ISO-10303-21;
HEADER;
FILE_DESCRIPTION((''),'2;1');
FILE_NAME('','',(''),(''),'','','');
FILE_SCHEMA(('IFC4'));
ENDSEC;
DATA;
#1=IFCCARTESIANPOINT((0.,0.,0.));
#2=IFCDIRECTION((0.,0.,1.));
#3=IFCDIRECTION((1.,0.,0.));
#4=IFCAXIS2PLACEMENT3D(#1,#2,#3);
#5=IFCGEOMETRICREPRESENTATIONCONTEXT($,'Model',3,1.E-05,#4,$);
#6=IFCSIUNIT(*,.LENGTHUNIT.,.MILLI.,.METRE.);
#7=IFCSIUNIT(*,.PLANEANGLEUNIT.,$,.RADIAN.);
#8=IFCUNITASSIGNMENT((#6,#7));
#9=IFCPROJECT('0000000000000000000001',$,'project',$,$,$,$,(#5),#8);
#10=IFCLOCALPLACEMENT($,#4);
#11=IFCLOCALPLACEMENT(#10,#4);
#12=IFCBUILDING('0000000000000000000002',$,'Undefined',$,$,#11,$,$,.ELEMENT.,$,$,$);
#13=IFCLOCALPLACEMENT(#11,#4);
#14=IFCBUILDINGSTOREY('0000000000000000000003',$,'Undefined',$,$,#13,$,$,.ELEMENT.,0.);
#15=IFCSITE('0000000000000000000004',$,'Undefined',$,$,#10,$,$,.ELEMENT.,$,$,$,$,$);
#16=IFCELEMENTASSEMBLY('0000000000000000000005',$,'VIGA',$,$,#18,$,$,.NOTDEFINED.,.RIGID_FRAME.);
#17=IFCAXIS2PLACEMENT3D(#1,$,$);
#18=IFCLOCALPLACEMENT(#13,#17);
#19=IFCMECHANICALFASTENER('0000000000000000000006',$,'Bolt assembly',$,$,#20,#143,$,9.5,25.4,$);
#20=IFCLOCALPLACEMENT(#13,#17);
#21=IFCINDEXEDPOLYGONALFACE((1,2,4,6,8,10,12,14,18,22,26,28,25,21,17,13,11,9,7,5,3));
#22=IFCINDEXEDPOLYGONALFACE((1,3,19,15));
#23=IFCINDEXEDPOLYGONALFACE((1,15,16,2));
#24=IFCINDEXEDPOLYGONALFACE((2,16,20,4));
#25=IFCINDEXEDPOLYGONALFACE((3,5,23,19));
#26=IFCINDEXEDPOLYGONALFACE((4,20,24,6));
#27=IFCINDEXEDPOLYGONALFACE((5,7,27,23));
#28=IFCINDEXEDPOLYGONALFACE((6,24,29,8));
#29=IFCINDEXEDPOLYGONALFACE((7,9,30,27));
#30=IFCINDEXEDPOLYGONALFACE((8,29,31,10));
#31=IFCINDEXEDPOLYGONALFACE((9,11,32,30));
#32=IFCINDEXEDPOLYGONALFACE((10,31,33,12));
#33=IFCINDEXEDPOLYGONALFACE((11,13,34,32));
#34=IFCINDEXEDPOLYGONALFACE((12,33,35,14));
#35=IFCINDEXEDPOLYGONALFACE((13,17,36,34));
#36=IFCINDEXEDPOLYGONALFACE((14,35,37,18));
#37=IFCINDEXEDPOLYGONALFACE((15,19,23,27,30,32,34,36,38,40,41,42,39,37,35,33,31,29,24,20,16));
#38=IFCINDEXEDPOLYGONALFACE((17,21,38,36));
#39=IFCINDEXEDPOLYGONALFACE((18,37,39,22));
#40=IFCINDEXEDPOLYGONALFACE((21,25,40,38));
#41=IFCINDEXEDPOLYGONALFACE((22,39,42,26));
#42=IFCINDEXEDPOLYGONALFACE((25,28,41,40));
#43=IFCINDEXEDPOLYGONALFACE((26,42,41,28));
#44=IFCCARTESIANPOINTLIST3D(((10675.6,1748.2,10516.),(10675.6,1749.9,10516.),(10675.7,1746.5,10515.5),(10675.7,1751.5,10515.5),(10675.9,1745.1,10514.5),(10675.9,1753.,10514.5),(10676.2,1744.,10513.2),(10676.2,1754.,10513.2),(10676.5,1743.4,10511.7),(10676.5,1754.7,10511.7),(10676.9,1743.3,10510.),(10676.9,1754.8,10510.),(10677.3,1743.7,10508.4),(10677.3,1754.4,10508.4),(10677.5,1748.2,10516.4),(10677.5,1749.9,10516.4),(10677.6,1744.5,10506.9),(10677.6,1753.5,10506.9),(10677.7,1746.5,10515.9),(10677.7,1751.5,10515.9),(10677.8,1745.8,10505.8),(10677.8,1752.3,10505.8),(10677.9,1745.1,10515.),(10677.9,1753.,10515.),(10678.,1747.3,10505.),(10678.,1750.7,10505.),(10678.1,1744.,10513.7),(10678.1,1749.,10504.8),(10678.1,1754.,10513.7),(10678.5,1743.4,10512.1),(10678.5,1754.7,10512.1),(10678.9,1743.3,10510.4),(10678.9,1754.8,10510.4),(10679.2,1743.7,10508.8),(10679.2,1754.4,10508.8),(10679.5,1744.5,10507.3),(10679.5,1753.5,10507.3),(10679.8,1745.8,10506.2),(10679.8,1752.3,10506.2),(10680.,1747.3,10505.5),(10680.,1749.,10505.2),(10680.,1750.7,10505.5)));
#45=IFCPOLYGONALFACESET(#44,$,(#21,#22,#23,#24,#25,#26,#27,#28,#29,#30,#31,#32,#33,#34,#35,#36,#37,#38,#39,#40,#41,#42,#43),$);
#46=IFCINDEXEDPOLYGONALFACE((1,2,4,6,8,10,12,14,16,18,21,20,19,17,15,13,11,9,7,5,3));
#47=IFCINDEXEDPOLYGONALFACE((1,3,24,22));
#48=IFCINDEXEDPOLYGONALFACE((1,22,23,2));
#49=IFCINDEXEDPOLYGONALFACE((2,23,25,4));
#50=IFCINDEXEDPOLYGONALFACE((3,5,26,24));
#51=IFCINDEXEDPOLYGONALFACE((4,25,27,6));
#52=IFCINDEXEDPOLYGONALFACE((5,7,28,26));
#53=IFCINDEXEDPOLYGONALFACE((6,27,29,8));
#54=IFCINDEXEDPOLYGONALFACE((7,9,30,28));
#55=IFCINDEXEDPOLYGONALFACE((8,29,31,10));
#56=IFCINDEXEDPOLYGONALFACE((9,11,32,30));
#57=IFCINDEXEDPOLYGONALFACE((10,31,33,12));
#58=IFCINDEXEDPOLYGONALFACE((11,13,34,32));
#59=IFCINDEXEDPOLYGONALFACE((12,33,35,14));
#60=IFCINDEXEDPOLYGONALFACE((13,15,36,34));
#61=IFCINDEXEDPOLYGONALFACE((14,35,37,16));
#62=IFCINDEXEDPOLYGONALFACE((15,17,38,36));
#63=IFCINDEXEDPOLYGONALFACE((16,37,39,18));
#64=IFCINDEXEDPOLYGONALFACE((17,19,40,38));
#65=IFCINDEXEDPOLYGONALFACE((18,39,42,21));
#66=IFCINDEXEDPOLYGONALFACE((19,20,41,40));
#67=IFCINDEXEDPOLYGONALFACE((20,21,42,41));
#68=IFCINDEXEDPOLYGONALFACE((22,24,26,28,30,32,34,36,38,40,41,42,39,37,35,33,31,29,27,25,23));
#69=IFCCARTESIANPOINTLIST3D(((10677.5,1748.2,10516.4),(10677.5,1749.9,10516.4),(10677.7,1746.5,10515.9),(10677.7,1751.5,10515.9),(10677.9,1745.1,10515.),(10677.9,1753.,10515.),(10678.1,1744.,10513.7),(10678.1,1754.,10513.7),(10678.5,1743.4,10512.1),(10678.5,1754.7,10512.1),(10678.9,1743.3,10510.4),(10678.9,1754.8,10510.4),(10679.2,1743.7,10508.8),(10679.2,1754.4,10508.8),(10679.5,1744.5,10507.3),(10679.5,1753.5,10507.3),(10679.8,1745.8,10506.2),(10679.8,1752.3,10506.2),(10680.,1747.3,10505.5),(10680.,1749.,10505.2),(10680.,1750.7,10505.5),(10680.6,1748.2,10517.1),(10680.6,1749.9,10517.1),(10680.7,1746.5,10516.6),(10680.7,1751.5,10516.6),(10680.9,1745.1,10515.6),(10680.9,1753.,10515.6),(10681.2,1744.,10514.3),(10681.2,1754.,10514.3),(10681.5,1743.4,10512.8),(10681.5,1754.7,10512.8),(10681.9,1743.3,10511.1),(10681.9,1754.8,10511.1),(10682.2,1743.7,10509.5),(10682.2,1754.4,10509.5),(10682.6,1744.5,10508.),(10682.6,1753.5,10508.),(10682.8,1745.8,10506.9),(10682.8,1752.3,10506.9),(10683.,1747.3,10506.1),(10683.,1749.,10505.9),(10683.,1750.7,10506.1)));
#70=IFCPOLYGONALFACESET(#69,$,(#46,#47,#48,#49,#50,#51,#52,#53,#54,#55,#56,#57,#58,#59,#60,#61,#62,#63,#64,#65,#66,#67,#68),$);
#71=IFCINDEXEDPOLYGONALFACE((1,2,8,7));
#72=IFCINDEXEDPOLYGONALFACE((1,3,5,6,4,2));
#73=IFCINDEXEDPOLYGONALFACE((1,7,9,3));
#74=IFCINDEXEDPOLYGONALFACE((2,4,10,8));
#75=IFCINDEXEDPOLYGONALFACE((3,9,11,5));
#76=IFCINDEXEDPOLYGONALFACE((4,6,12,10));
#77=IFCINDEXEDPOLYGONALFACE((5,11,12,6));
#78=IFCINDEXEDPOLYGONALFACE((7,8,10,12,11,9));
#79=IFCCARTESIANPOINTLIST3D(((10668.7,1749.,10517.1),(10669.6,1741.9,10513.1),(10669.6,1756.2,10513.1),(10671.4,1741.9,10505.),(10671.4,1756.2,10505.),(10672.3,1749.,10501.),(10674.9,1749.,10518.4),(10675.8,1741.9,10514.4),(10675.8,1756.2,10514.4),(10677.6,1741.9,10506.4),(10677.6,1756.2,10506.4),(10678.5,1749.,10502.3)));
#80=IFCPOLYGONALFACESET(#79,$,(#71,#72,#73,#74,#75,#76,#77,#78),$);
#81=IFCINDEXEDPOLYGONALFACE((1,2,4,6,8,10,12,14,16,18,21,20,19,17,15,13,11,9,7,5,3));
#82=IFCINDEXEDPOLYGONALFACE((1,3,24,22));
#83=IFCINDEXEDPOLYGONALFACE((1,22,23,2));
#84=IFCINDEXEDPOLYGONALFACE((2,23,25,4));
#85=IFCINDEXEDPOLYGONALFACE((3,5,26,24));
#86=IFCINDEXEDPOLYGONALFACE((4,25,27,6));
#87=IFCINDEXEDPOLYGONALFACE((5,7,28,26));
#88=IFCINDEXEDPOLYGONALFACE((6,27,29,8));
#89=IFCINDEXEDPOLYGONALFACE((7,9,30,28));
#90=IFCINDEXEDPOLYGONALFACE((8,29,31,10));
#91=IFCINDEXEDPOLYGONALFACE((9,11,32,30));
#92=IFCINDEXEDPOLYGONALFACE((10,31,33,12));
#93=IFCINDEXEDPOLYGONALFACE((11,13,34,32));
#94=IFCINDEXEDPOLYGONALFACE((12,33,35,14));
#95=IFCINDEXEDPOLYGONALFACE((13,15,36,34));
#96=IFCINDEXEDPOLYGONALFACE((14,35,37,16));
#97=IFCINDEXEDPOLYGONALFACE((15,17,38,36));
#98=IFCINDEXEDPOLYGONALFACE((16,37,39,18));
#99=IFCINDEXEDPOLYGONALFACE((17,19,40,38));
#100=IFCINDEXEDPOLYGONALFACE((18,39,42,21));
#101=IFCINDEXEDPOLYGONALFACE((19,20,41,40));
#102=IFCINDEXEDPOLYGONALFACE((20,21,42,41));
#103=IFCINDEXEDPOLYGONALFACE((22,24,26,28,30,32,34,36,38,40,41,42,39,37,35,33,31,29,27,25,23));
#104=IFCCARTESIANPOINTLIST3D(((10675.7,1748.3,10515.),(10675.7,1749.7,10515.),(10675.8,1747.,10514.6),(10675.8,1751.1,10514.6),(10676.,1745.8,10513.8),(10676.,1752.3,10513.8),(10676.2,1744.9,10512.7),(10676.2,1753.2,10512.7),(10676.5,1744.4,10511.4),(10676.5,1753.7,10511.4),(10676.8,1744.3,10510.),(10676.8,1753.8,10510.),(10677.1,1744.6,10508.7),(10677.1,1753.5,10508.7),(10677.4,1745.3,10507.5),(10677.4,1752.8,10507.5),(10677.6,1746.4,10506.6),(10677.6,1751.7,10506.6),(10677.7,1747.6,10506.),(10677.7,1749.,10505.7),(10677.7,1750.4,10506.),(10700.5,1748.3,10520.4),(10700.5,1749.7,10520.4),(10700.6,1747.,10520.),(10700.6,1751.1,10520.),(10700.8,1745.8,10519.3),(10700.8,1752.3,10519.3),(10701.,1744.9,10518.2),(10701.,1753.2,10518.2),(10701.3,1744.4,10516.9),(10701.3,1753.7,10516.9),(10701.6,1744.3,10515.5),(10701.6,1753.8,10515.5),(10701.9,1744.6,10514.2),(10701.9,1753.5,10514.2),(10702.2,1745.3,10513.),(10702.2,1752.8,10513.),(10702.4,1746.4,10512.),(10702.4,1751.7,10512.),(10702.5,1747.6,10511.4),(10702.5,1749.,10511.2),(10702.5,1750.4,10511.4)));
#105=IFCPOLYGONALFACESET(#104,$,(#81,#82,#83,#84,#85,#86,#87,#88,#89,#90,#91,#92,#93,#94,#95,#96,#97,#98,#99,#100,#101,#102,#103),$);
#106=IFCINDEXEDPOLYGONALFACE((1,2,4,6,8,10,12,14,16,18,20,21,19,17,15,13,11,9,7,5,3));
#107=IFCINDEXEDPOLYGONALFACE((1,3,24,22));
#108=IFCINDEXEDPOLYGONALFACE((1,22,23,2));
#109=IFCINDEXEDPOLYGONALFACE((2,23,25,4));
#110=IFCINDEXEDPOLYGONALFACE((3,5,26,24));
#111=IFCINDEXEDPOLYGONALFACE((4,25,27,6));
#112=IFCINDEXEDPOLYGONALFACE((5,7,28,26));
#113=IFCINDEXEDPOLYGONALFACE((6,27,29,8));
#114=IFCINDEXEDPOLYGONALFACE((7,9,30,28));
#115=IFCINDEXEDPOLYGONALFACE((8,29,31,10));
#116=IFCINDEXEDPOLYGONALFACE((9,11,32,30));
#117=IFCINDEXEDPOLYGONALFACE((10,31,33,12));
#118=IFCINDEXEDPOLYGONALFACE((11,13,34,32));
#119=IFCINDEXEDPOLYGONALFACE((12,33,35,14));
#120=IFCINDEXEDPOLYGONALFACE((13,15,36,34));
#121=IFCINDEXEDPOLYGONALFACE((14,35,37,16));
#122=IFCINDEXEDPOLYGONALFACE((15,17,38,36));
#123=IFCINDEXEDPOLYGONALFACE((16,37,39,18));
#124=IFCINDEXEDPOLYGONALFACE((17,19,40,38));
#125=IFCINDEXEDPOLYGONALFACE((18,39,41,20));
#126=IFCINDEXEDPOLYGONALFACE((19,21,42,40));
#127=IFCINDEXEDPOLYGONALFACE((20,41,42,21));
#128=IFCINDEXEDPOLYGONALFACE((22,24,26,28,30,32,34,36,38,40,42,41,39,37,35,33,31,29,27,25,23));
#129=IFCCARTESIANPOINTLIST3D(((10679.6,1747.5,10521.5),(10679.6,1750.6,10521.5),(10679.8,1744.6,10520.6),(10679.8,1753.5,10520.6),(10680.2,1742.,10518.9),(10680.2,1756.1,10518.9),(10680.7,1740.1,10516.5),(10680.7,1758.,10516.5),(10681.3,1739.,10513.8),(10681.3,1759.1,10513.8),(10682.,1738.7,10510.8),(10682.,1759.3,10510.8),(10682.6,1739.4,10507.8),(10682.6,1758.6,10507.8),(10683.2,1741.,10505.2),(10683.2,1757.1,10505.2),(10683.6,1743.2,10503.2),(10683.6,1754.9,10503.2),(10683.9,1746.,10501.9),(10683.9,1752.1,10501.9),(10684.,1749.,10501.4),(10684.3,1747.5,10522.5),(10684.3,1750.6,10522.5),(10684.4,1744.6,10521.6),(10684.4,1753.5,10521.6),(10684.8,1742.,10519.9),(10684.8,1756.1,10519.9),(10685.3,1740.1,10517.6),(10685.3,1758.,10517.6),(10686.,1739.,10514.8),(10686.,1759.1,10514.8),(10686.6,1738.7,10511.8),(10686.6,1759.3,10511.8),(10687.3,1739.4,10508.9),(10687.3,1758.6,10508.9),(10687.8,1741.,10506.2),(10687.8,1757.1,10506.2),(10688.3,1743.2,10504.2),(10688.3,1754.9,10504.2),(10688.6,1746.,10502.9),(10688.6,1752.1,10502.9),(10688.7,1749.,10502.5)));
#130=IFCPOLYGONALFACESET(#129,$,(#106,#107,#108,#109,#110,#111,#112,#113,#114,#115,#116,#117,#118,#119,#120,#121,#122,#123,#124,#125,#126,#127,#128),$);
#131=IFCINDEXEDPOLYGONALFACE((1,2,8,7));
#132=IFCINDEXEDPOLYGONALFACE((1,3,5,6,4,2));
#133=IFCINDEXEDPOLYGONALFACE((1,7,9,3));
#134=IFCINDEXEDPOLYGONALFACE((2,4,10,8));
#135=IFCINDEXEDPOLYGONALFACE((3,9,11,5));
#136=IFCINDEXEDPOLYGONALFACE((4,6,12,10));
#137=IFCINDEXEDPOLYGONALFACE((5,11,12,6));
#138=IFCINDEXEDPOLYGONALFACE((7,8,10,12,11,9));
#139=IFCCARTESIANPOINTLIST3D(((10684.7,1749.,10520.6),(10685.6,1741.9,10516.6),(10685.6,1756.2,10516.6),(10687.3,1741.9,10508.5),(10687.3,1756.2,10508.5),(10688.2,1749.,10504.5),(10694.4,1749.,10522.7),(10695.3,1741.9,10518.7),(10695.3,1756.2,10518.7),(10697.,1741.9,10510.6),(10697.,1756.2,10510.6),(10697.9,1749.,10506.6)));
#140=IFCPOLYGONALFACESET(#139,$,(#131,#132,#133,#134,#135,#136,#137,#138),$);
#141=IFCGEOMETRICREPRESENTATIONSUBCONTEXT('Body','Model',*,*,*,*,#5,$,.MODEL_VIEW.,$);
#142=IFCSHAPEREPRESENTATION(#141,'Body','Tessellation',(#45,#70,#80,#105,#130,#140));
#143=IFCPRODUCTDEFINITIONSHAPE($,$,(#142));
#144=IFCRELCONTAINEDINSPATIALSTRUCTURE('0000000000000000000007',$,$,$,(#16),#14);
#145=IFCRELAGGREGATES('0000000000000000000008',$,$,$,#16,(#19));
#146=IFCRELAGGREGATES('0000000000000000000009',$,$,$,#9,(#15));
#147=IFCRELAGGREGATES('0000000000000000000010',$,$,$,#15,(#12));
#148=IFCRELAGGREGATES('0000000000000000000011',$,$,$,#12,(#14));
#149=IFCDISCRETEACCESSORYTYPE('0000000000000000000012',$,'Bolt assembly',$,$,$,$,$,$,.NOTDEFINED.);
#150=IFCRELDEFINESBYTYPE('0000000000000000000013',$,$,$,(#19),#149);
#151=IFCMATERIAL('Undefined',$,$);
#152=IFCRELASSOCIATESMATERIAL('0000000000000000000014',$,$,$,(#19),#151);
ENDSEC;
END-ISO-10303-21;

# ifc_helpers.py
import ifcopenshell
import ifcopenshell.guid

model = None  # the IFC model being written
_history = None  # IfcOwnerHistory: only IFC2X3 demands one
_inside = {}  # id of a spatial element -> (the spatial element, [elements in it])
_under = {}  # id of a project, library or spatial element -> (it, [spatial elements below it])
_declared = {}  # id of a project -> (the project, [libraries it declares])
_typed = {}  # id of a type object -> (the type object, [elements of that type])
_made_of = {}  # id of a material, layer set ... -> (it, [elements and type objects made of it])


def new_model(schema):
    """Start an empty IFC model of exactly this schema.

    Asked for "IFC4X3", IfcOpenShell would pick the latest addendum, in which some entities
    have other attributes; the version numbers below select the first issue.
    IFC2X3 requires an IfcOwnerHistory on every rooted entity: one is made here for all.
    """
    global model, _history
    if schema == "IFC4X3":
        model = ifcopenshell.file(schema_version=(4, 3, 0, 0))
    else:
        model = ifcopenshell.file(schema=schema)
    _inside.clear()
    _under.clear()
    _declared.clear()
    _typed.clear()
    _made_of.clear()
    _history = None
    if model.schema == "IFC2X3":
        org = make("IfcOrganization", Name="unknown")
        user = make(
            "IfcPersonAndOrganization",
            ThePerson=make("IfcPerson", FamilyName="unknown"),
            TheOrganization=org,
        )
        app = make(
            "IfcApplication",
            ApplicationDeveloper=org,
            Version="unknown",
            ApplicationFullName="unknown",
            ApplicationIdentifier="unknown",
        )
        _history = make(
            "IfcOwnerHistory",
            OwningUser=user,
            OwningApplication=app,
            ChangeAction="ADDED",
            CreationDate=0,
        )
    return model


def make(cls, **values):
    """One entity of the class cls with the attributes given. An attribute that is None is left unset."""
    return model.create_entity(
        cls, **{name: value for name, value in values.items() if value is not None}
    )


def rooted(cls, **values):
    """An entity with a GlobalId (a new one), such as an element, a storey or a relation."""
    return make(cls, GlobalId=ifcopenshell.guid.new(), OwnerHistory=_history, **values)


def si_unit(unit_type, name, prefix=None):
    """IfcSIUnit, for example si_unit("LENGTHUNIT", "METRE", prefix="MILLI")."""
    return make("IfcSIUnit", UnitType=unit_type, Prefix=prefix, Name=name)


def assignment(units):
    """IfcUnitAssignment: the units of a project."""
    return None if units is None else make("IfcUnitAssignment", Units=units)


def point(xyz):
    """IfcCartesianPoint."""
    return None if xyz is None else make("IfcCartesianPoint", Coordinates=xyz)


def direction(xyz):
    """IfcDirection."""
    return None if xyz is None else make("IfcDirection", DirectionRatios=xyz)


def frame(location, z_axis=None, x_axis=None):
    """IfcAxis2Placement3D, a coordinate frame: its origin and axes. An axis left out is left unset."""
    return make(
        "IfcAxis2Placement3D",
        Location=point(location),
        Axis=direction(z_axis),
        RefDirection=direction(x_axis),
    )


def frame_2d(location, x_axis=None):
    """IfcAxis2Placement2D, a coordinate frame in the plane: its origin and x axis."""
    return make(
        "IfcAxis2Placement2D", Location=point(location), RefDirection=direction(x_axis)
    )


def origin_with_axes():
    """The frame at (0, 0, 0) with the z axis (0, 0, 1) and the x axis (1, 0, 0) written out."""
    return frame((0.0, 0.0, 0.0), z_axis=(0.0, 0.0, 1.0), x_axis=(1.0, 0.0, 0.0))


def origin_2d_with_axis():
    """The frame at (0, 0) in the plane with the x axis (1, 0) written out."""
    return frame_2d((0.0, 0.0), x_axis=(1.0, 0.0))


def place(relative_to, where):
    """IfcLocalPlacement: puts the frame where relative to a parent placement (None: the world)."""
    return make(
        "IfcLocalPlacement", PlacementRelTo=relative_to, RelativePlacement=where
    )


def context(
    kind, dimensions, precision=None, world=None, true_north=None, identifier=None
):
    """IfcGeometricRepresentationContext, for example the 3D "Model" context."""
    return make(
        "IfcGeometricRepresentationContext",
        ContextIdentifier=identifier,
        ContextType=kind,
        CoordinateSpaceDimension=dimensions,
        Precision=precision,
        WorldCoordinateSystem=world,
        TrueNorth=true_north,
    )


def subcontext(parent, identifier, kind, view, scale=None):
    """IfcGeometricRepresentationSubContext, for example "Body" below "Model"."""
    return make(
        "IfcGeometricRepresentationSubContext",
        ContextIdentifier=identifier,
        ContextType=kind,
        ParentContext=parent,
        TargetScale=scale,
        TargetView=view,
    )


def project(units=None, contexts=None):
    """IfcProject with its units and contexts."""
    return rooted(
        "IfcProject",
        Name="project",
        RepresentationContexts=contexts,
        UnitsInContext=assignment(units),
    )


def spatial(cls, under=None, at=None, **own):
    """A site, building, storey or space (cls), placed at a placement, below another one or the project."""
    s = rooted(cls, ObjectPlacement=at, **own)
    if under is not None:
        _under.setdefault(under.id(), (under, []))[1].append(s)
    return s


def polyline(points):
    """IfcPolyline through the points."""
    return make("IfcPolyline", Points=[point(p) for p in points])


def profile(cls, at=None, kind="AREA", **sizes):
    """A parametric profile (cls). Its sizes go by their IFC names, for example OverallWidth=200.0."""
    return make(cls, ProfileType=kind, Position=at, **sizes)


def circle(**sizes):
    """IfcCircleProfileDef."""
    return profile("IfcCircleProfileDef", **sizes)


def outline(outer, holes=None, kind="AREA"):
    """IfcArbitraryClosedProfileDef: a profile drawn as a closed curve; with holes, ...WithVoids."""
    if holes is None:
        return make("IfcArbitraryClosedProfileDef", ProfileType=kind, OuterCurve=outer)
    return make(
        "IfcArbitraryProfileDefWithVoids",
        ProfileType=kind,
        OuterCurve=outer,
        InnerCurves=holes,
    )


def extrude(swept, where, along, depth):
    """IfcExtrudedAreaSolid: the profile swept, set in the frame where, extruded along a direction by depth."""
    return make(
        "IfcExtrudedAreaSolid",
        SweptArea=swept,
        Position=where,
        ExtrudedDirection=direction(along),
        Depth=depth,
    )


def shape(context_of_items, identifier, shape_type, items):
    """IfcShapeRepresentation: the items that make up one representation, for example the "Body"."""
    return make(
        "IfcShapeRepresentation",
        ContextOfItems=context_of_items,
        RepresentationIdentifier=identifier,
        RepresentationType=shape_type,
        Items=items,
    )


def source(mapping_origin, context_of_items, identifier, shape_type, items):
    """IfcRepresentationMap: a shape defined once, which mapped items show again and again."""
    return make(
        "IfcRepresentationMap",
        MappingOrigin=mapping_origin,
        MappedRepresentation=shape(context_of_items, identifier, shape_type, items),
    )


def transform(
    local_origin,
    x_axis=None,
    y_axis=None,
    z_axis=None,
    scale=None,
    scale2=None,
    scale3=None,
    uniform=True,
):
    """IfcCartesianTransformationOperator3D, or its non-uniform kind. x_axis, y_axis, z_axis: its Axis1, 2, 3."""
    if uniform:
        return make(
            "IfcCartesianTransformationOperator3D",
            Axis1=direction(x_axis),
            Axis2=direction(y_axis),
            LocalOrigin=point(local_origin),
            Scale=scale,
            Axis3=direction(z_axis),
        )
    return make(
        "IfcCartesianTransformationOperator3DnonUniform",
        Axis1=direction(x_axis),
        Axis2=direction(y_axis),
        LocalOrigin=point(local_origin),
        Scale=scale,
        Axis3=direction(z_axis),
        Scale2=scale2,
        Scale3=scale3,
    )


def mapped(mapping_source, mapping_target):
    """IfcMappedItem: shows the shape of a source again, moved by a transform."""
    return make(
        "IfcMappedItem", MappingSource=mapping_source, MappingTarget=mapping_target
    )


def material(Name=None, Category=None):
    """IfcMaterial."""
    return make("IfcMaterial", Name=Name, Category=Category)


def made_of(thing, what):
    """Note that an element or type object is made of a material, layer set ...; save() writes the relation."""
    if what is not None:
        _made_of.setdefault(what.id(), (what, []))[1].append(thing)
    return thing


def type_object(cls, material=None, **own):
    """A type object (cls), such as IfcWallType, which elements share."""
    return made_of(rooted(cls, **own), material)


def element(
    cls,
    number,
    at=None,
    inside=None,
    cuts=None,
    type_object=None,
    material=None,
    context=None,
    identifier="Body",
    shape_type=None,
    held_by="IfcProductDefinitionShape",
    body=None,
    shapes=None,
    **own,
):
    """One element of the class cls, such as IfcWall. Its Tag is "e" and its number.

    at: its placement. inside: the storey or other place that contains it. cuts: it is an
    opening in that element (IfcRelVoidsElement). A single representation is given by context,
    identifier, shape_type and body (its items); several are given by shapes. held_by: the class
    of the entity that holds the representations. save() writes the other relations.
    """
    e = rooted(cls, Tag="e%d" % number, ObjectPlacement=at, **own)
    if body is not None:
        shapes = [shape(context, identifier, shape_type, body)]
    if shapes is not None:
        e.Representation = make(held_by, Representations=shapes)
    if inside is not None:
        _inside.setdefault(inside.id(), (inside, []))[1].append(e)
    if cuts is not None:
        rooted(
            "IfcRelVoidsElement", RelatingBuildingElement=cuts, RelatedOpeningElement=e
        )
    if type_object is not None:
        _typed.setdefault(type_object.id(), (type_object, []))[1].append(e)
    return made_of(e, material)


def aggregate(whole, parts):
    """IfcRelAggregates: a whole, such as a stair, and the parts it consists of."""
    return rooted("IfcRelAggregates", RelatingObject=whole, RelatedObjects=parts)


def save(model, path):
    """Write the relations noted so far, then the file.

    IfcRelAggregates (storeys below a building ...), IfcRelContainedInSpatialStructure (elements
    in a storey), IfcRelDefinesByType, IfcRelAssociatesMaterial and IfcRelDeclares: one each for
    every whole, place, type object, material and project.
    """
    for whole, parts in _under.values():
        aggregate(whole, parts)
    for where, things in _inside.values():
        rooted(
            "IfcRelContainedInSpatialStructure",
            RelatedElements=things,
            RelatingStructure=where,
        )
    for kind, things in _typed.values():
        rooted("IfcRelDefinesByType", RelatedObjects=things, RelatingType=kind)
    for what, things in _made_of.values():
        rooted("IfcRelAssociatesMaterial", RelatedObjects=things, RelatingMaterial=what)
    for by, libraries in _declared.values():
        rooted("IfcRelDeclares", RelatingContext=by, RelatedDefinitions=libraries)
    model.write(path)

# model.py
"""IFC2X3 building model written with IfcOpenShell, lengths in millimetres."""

from ifc_helpers import new_model, si_unit, frame, origin_with_axes, origin_2d_with_axis, place, context, subcontext, project, spatial, polyline, circle, outline, extrude, source, transform, mapped, material, type_object, element, aggregate, save


model = new_model("IFC2X3")

# Units and contexts
model_context = context("Model", 3, precision=1e-05, world=origin_with_axes())
body_context = subcontext(model_context, "Body", "Model", "MODEL_VIEW")
ifc_project = project(units=[si_unit("LENGTHUNIT", "METRE", prefix="MILLI"), si_unit("PLANEANGLEUNIT", "RADIAN")], contexts=[model_context])

# Site, building, storey
site_placement = place(None, origin_with_axes())
site = spatial("IfcSite", under=ifc_project, at=site_placement, Name="Undefined", CompositionType="ELEMENT")
building_placement = place(site_placement, origin_with_axes())
building = spatial("IfcBuilding", under=site, at=building_placement, Name="Undefined", CompositionType="ELEMENT")
storey_placement = place(building_placement, origin_with_axes())
storey = spatial("IfcBuildingStorey", under=building, at=storey_placement, Name="Undefined", CompositionType="ELEMENT", Elevation=0.0)

# Element assembly
assembly_1_placement = place(storey_placement, origin_with_axes())
assembly_1 = element("IfcElementAssembly", 1, at=assembly_1_placement, inside=storey, Name="VIGA", AssemblyPlace="NOTDEFINED", PredefinedType="RIGID_FRAME")

# Mechanical fastener
ifc_material_1 = material(Name="Undefined")
discrete_accessory_type_1 = type_object("IfcDiscreteAccessoryType", Name="Bolt assembly")
shared_shape_1 = source(origin_with_axes(), body_context, "Body", "SweptSolid", [
    extrude(circle(Radius=5.8, at=origin_2d_with_axis()), frame((0.0, -5.1, 0.0), z_axis=(0.0, 1.0, 0.0), x_axis=(1.0, 0.0, 0.0)), (0.0, 0.0, 1.0), 2.0),
    extrude(circle(Radius=5.8, at=origin_2d_with_axis()), frame((0.0, -3.1, 0.0), z_axis=(0.0, 1.0, 0.0), x_axis=(1.0, 0.0, 0.0)), (0.0, 0.0, 1.0), 3.1),
    extrude(outline(polyline([(8.2, 0.0), (4.1, 7.1), (-4.1, 7.1), (-8.2, 0.0), (-4.1, -7.1), (4.1, -7.1), (8.2, 0.0)])), frame((0.0, -11.6, 0.0), z_axis=(0.0, 1.0, 0.0), x_axis=(1.0, 0.0, 0.0)), (0.0, 0.0, 1.0), 6.3),
    extrude(circle(Radius=4.8, at=origin_2d_with_axis()), frame((0.0, -5.2, 0.0), z_axis=(0.0, 1.0, 0.0), x_axis=(1.0, 0.0, 0.0)), (0.0, 0.0, 1.0), 25.4),
    extrude(circle(Radius=10.3, at=origin_2d_with_axis()), frame((0.0, 0.0, 0.0), z_axis=(0.0, 1.0, 0.0), x_axis=(1.0, 0.0, 0.0)), (0.0, 0.0, 1.0), 4.8),
    extrude(outline(polyline([(8.3, 0.0), (4.1, 7.1), (-4.1, 7.1), (-8.3, 0.0), (-4.1, -7.1), (4.1, -7.1), (8.3, 0.0)])), frame((0.0, 4.8, 0.0), z_axis=(0.0, 1.0, 0.0), x_axis=(1.0, 0.0, 0.0)), (0.0, 0.0, 1.0), 9.9),
])
mechanical_fastener_1_placement = place(assembly_1_placement, frame((10681.8, 1749.0, 10511.5), z_axis=(0.000001, -1.0, 0.0), x_axis=(0.214906, 0.0, -0.976635)))
mechanical_fastener_1 = element("IfcMechanicalFastener", 2, at=mechanical_fastener_1_placement, type_object=discrete_accessory_type_1, material=ifc_material_1, Name="Bolt assembly", NominalDiameter=9.5, NominalLength=25.4, context=body_context, shape_type="MappedRepresentation", body=[
    mapped(shared_shape_1, transform((0.0, 0.0, 0.0))),
])
aggregate(assembly_1, [mechanical_fastener_1])

save(model, "model.ifc")
